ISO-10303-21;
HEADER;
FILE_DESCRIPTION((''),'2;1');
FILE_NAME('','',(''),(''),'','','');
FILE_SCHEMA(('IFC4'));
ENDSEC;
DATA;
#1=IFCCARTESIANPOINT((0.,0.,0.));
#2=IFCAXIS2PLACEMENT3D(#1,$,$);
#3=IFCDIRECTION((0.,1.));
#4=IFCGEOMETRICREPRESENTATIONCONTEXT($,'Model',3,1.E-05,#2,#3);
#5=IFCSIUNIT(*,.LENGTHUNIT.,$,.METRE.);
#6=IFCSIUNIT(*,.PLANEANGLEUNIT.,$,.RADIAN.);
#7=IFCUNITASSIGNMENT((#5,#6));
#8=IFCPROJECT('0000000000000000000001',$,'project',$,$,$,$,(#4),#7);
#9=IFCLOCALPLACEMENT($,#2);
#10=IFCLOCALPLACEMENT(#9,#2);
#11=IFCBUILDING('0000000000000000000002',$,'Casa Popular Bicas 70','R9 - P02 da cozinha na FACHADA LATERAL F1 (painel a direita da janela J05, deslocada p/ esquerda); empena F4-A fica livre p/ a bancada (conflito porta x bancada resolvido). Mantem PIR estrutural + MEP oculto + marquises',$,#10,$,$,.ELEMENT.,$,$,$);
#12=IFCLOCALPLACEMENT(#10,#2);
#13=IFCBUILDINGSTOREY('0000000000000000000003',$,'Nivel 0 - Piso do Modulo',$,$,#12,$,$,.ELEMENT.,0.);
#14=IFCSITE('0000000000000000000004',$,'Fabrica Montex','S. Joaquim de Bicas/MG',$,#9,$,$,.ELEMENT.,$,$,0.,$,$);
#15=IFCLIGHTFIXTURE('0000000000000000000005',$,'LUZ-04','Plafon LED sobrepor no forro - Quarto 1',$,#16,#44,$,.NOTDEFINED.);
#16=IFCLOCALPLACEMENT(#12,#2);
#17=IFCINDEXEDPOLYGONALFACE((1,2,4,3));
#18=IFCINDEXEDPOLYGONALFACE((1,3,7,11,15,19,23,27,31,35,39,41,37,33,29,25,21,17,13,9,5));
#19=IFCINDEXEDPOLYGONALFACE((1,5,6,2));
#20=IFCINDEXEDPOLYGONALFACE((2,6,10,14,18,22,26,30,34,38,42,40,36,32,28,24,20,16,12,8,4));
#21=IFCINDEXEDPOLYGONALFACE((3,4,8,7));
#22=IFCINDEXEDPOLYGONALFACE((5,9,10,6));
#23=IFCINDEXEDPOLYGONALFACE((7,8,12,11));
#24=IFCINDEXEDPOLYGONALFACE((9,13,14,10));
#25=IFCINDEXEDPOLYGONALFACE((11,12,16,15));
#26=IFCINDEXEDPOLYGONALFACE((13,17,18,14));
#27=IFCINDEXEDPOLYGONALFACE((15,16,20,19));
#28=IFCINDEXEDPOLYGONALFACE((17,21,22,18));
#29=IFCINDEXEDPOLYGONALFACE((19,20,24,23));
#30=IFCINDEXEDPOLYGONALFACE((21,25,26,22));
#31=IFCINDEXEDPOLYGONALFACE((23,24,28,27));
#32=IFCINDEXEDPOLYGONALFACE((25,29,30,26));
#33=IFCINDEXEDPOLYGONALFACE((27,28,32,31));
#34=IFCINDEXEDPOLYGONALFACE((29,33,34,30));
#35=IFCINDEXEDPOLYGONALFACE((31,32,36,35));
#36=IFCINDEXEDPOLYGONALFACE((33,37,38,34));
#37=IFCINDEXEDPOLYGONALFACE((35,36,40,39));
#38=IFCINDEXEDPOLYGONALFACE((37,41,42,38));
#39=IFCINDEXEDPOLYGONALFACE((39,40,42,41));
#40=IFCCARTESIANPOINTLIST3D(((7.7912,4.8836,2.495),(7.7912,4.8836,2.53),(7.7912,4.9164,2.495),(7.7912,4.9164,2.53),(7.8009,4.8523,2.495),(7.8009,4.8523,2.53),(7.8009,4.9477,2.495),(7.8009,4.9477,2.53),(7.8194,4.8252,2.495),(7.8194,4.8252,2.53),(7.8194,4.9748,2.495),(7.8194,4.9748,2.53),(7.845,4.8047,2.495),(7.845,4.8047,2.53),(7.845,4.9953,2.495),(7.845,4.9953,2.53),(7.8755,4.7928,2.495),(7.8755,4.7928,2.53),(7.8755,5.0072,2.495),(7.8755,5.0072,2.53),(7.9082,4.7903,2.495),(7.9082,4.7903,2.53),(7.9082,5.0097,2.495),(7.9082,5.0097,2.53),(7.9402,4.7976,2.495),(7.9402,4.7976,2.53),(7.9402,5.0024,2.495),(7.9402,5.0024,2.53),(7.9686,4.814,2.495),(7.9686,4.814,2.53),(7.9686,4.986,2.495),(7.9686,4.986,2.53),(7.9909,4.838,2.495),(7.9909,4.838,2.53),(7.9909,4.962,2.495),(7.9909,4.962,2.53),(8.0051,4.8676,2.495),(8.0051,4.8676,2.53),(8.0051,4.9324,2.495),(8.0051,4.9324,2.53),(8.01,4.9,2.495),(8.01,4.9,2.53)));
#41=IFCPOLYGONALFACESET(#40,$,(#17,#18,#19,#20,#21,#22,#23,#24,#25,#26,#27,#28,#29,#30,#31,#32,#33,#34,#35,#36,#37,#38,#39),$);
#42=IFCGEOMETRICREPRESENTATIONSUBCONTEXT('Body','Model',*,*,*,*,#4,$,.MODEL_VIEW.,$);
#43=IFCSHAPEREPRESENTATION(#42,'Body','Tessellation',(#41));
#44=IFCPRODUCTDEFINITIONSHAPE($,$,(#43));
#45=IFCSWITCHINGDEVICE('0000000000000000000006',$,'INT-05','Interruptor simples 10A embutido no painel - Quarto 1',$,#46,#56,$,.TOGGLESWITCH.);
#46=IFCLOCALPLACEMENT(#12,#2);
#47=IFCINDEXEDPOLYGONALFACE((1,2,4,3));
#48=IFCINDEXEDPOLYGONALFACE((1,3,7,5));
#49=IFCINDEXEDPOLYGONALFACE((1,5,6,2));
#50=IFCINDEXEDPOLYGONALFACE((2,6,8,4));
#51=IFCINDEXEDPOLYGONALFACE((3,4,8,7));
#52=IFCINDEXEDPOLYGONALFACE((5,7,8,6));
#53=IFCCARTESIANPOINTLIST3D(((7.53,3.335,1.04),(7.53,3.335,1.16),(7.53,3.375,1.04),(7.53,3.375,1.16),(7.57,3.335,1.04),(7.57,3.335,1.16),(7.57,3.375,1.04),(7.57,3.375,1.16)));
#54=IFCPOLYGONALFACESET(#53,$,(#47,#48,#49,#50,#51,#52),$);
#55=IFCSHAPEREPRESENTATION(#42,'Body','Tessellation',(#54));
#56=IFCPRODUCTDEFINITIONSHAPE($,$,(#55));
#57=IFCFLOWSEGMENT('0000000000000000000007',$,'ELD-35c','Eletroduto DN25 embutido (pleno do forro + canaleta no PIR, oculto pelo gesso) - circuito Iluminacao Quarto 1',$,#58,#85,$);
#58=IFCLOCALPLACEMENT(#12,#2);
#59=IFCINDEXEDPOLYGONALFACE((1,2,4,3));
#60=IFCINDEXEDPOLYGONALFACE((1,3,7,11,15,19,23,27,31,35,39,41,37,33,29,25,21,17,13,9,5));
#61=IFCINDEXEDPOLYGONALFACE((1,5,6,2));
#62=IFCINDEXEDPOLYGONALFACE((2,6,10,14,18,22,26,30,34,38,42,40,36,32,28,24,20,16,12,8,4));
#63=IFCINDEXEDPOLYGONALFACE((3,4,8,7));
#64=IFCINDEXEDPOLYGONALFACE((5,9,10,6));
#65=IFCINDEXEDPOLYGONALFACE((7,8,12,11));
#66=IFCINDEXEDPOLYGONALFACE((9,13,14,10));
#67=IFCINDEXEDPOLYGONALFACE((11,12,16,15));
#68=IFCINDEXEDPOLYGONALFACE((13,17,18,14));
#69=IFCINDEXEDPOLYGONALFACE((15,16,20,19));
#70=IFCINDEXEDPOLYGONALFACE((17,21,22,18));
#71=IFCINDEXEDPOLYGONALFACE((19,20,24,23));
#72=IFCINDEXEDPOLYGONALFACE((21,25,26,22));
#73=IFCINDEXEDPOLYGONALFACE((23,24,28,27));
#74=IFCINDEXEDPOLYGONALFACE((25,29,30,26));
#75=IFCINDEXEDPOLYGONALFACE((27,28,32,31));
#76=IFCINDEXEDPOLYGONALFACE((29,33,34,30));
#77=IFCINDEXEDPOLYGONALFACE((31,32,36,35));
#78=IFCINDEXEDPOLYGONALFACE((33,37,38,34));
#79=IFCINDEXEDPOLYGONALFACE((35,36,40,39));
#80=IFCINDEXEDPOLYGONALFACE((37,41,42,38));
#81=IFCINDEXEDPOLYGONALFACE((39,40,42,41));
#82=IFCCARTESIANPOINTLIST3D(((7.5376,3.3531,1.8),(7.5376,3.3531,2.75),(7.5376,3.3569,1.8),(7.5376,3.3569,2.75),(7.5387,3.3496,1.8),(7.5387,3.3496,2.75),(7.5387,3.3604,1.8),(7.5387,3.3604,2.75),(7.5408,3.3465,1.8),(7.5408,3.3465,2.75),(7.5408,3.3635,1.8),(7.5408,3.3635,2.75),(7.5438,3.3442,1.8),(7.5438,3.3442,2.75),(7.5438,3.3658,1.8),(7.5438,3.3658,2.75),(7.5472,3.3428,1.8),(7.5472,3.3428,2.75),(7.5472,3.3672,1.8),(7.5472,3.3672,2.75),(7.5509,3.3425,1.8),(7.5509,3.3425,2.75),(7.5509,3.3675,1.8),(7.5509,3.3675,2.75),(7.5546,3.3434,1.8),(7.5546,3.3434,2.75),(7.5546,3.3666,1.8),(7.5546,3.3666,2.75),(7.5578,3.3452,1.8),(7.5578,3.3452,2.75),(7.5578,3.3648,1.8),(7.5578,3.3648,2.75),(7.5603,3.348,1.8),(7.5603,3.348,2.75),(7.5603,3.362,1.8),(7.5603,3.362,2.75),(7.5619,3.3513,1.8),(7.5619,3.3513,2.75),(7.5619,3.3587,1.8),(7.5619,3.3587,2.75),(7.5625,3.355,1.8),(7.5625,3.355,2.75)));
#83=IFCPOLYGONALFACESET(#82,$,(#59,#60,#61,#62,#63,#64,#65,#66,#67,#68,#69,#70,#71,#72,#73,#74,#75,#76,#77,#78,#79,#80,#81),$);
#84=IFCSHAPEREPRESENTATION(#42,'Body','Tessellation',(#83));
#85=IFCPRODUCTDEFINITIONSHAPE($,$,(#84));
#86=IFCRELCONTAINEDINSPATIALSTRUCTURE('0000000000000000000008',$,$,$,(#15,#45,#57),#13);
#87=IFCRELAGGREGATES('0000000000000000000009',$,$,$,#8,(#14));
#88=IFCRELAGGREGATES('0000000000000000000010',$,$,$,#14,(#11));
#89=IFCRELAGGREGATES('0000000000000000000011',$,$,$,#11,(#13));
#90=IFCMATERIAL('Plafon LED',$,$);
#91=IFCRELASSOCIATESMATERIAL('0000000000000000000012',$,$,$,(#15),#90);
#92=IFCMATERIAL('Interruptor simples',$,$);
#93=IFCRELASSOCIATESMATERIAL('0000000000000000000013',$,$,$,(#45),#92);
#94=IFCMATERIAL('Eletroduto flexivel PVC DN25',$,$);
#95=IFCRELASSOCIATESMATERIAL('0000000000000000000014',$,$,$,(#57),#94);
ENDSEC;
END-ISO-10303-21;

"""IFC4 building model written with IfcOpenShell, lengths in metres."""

from ifc_helpers import new_model, si_unit, direction, frame, frame_2d, origin, origin_2d, place, context, subcontext, project, spatial, rectangle, circle, extrude, material, element, save


model = new_model("IFC4")

# Units and contexts
model_context = context("Model", 3, precision=1e-05, world=origin(), true_north=direction((0.0, 1.0)))
body_context = subcontext(model_context, "Body", "Model", "MODEL_VIEW")
ifc_project = project(units=[si_unit("LENGTHUNIT", "METRE"), si_unit("PLANEANGLEUNIT", "RADIAN")], contexts=[model_context])

# Site, building, storey
site_placement = place(None, origin())
site = spatial("IfcSite", under=ifc_project, at=site_placement, Name="Fabrica Montex", Description="S. Joaquim de Bicas/MG", CompositionType="ELEMENT", RefElevation=0.0)
building_placement = place(site_placement, origin())
building = spatial("IfcBuilding", under=site, at=building_placement, Name="Casa Popular Bicas 70", Description="R9 - P02 da cozinha na FACHADA LATERAL F1 (painel a direita da janela J05, deslocada p/ esquerda); empena F4-A fica livre p/ a bancada (conflito porta x bancada resolvido). Mantem PIR estrutural + MEP oculto + marquises", CompositionType="ELEMENT")
storey_placement = place(building_placement, origin())
storey = spatial("IfcBuildingStorey", under=building, at=storey_placement, Name="Nivel 0 - Piso do Modulo", CompositionType="ELEMENT", Elevation=0.0)

# Shared definitions
ifc_material_1 = material(Name="Eletroduto flexivel PVC DN25")

# Light fixture
ifc_material_2 = material(Name="Plafon LED")
light_fixture_placement = place(storey_placement, frame((7.9, 4.9, 2.495)))
element("IfcLightFixture", 1, at=light_fixture_placement, inside=storey, material=ifc_material_2, Name="LUZ-04", Description="Plafon LED sobrepor no forro - Quarto 1", PredefinedType="NOTDEFINED", context=body_context, shape_type="SweptSolid", body=[
    extrude(circle(Radius=0.11, at=origin_2d()), origin(), (0.0, 0.0, 1.0), 0.035),
])

# Switching device
ifc_material_3 = material(Name="Interruptor simples")
switching_device_placement = place(storey_placement, frame((7.53, 3.335, 1.04)))
element("IfcSwitchingDevice", 2, at=switching_device_placement, inside=storey, material=ifc_material_3, Name="INT-05", Description="Interruptor simples 10A embutido no painel - Quarto 1", PredefinedType="TOGGLESWITCH", context=body_context, shape_type="SweptSolid", body=[
    extrude(rectangle(XDim=0.04, YDim=0.04, at=frame_2d((0.02, 0.02))), origin(), (0.0, 0.0, 1.0), 0.12),
])

# Flow segment
flow_segment_1_placement = place(storey_placement, frame((7.55, 3.355, 2.75), z_axis=(0.0, 0.0, -1.0), x_axis=(1.0, 0.0, 0.0)))
element("IfcFlowSegment", 3, at=flow_segment_1_placement, inside=storey, material=ifc_material_1, Name="ELD-35c", Description="Eletroduto DN25 embutido (pleno do forro + canaleta no PIR, oculto pelo gesso) - circuito Iluminacao Quarto 1", context=body_context, shape_type="SweptSolid", body=[
    extrude(circle(Radius=0.0125, at=origin_2d()), origin(), (0.0, 0.0, 1.0), 0.95),
])

save(model, "model.ifc")
